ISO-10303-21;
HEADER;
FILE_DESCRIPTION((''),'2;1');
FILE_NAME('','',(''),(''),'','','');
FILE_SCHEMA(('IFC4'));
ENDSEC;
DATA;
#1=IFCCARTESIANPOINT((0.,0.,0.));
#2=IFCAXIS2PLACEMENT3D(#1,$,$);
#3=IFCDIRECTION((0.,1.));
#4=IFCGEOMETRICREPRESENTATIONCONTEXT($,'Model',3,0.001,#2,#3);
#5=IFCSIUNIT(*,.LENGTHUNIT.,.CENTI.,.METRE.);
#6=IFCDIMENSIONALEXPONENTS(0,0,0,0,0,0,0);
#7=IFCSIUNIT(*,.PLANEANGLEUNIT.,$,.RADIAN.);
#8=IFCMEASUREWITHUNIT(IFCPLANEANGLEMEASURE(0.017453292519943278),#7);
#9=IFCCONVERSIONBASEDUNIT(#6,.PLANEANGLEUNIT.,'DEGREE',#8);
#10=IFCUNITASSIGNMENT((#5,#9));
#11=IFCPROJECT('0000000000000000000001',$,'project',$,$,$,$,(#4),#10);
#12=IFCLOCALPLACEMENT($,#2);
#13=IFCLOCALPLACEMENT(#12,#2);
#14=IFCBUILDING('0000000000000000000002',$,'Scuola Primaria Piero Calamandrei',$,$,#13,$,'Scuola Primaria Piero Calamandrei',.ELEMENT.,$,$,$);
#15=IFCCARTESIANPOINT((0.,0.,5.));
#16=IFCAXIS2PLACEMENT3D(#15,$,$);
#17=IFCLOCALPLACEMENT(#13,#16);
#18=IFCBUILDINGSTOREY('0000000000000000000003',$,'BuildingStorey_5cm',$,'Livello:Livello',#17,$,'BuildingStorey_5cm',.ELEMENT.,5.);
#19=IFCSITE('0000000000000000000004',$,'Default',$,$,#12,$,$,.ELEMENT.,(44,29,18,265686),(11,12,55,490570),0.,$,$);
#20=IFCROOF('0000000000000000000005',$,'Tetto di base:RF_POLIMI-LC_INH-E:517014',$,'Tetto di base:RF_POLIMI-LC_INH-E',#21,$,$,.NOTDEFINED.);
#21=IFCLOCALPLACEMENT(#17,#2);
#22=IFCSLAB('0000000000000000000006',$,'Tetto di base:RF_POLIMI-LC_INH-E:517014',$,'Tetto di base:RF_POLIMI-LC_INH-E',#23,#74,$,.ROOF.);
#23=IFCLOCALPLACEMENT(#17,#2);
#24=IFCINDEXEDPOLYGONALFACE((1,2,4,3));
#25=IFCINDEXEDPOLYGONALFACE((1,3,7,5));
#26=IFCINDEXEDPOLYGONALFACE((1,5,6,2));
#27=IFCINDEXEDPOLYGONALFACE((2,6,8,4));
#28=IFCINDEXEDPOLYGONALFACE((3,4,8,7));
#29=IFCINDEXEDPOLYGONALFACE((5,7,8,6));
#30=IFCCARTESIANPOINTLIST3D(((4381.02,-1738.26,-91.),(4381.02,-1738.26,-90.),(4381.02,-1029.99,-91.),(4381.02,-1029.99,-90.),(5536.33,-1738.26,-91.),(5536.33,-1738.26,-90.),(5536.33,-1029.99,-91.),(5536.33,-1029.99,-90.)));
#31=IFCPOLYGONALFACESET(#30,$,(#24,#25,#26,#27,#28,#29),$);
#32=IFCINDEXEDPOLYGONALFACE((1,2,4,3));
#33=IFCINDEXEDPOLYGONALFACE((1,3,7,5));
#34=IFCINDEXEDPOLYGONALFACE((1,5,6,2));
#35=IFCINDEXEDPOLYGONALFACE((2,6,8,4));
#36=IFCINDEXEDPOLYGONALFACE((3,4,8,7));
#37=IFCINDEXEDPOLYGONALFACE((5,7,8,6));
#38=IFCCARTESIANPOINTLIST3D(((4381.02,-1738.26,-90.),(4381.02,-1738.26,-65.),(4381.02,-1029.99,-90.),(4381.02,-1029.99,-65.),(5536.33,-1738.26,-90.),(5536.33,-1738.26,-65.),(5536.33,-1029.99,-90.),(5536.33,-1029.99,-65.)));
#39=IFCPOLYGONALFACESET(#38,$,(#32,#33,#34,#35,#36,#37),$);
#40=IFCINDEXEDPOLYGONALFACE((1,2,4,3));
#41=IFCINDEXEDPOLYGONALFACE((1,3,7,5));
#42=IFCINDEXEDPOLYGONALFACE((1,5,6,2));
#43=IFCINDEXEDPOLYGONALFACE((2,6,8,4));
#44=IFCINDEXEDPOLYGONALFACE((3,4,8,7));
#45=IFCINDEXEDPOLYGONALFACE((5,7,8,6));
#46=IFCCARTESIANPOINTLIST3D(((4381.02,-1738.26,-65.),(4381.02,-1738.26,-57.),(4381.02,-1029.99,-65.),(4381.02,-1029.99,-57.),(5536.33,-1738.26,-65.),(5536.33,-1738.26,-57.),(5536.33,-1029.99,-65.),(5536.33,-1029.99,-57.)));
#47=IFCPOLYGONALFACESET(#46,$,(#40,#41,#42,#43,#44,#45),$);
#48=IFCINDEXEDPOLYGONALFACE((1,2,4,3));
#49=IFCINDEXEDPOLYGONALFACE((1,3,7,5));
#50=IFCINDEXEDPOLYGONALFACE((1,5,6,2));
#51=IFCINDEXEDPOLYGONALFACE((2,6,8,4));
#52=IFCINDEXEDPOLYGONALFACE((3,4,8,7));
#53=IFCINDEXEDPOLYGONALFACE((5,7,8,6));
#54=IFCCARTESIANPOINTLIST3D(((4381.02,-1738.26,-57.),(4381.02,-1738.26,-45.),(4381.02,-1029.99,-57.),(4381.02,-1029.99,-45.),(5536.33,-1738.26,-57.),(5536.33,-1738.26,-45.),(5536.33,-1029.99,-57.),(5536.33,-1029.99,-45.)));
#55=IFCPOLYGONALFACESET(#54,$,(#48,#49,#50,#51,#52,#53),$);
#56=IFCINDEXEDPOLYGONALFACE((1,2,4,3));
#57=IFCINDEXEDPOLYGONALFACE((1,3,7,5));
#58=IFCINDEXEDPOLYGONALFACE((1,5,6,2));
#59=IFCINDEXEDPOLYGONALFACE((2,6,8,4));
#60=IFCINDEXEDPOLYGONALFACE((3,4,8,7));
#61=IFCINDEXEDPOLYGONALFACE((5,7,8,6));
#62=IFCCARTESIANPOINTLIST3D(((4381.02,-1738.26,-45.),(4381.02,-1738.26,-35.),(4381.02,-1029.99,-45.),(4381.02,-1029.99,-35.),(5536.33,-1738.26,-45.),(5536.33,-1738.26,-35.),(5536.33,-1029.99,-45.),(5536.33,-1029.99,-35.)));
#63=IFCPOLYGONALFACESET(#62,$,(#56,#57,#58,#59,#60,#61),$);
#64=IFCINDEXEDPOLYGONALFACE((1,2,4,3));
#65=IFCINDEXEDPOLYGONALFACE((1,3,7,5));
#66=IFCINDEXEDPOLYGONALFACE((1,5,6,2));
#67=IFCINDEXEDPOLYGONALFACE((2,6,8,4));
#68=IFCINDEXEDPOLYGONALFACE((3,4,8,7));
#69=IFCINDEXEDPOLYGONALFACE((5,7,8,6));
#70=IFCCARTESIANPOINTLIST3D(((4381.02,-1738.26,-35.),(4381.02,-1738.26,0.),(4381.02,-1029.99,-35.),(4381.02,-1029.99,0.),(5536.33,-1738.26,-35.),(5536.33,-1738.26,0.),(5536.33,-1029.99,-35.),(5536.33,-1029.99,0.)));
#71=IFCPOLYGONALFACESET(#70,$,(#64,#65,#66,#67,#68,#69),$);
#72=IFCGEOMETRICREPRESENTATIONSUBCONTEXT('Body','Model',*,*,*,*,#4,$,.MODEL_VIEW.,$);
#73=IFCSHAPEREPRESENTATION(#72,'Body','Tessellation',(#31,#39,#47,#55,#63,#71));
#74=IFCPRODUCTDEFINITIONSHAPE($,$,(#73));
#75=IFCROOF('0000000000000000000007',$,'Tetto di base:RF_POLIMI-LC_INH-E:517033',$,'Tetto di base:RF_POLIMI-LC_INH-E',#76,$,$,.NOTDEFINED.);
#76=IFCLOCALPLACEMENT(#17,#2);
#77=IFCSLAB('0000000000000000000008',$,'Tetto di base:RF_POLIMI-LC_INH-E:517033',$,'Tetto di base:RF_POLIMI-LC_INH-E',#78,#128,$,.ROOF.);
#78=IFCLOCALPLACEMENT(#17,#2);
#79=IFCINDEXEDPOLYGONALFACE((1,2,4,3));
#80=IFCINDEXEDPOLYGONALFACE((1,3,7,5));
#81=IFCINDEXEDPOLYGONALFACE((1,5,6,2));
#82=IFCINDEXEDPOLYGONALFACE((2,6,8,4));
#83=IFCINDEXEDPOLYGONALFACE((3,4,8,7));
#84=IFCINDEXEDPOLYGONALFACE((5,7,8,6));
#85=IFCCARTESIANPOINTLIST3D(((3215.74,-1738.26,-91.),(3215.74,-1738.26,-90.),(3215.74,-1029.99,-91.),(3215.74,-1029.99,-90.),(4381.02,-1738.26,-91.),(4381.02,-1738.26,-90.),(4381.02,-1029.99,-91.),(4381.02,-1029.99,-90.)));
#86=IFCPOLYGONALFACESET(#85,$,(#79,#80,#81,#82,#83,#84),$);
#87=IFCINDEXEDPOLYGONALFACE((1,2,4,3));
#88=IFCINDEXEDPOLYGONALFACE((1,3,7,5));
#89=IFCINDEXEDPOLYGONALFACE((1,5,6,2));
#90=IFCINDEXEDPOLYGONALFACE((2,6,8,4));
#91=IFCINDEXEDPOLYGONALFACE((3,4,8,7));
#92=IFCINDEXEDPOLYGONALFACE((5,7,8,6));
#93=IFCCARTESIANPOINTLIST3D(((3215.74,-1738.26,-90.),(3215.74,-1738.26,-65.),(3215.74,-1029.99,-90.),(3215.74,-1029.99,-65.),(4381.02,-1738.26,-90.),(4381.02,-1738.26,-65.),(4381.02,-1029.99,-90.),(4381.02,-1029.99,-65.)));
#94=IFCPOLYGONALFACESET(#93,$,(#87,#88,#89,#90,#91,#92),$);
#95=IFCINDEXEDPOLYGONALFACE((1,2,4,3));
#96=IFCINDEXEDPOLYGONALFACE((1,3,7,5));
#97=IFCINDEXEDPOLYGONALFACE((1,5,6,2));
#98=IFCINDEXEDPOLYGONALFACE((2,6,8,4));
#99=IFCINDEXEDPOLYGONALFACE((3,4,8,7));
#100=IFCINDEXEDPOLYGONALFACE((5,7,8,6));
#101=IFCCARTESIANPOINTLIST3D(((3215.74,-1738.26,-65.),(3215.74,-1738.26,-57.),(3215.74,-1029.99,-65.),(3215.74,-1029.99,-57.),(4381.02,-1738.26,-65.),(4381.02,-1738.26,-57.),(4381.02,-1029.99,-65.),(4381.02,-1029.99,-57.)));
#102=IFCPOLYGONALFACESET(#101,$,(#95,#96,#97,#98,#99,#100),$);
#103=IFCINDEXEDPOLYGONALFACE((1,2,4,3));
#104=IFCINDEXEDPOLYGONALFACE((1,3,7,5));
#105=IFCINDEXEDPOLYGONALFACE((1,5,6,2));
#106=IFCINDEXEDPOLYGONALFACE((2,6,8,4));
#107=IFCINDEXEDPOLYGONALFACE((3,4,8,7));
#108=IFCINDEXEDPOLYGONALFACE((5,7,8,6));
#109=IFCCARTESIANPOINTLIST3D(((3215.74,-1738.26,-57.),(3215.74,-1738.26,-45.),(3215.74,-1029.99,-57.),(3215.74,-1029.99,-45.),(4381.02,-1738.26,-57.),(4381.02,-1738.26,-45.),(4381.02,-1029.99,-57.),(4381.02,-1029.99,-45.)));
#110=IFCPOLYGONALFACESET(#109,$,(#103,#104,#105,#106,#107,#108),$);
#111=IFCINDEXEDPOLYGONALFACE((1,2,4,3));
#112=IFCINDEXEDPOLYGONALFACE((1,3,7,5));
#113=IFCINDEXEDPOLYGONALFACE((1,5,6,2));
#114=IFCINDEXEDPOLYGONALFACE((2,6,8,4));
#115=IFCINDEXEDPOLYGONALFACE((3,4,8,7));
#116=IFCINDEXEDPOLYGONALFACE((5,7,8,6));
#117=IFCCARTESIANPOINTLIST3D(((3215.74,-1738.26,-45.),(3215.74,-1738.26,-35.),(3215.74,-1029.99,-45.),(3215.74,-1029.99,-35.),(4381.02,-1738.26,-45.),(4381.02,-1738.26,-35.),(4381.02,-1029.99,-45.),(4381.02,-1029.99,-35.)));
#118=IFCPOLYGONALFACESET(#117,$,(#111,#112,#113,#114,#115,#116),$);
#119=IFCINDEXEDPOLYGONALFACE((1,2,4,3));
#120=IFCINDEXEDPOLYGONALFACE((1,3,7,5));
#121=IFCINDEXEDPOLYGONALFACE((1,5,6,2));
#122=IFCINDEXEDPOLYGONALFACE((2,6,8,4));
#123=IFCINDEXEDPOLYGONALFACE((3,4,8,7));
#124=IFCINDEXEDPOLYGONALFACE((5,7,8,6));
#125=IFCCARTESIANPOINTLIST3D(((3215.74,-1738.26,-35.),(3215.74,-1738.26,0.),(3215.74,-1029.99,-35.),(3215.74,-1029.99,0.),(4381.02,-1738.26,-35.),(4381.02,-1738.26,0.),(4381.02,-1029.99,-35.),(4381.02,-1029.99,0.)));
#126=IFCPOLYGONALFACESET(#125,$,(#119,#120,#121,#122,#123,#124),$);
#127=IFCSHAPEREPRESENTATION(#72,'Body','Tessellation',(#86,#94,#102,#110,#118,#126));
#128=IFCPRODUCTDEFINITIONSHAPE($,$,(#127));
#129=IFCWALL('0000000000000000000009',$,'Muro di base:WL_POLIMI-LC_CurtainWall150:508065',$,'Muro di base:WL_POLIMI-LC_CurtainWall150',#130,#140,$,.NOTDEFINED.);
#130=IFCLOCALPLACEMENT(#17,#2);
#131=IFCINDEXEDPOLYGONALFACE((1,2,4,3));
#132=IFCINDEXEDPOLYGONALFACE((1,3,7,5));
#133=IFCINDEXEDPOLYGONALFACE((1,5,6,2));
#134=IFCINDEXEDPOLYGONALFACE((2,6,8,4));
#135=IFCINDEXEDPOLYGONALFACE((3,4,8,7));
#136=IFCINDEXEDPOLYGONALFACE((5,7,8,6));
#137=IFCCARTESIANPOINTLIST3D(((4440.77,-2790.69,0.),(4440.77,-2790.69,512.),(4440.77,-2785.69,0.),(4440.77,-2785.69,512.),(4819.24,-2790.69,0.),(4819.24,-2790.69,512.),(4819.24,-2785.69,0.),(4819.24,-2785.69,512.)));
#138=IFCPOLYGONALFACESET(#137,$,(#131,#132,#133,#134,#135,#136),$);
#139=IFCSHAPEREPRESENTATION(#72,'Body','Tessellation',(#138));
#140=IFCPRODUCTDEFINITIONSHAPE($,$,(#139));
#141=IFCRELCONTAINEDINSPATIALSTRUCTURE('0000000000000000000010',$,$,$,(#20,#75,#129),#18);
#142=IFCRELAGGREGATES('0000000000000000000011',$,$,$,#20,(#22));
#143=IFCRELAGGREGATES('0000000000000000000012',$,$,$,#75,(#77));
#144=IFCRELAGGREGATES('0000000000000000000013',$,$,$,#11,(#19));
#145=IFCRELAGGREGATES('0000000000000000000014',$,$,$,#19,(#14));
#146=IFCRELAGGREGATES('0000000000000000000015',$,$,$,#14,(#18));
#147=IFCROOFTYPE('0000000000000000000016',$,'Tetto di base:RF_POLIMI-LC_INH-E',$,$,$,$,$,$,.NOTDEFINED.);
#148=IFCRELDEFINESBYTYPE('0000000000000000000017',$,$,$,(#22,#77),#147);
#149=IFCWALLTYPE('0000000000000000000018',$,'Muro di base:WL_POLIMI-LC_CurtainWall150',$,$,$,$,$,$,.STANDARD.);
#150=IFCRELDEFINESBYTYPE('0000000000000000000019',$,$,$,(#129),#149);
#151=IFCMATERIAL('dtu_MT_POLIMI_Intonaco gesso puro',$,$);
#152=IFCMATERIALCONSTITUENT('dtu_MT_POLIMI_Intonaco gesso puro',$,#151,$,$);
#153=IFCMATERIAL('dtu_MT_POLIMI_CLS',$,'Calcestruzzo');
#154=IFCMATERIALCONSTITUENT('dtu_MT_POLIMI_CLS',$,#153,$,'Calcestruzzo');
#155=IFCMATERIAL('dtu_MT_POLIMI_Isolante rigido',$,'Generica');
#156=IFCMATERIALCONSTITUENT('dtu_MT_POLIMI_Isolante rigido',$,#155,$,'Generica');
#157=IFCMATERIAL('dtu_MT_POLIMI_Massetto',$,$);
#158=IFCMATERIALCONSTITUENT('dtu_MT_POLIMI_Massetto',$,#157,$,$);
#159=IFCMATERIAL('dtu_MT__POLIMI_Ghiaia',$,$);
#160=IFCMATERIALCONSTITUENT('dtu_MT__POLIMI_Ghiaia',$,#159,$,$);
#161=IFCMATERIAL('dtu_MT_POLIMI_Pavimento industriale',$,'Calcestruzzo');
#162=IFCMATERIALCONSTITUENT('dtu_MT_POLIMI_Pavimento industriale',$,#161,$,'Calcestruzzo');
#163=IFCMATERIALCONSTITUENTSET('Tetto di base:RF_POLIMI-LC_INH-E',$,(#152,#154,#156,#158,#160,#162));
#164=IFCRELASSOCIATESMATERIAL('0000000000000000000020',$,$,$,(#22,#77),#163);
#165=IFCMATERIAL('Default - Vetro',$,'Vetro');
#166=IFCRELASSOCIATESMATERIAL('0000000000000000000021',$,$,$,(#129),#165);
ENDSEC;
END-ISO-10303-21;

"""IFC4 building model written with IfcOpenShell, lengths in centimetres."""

from ifc_helpers import new_model, entity, si_unit, converted_unit, direction, frame, origin, place, context, subcontext, project, spatial, indexed_curve, outline, extrude, material, constituent, constituent_set, type_object, element, aggregate, save


model = new_model("IFC4")

# Units and contexts
model_context = context("Model", 3, precision=0.001, world=origin(), true_north=direction((0.0, 1.0)))
body_context = subcontext(model_context, "Body", "Model", "MODEL_VIEW")
ifc_project = project(units=[si_unit("LENGTHUNIT", "METRE", prefix="CENTI"), converted_unit("PLANEANGLEUNIT", "DEGREE", entity("IfcPlaneAngleMeasure", 0.017453292519943278), si_unit("PLANEANGLEUNIT", "RADIAN"), dimensions=[0, 0, 0, 0, 0, 0, 0])], contexts=[model_context])

# Site, building, storey
site_placement = place(None, origin())
site = spatial("IfcSite", under=ifc_project, at=site_placement, Name="Default", CompositionType="ELEMENT", RefLatitude=(44, 29, 18, 265686), RefLongitude=(11, 12, 55, 490570), RefElevation=0.0)
building_placement = place(site_placement, origin())
building = spatial("IfcBuilding", under=site, at=building_placement, Name="Scuola Primaria Piero Calamandrei", LongName="Scuola Primaria Piero Calamandrei", CompositionType="ELEMENT")
storey_placement = place(building_placement, frame((0.0, 0.0, 5.0)))
storey = spatial("IfcBuildingStorey", under=building, at=storey_placement, Name="BuildingStorey_5cm", ObjectType="Livello:Livello", LongName="BuildingStorey_5cm", CompositionType="ELEMENT", Elevation=5.0)

# Roofs, slabs
roof_1_placement = place(storey_placement, frame((4381.02, -1738.26, -91.0)))
roof_1 = element("IfcRoof", 1, at=roof_1_placement, inside=storey, Name="Tetto di base:RF_POLIMI-LC_INH-E:517014", ObjectType="Tetto di base:RF_POLIMI-LC_INH-E", PredefinedType="NOTDEFINED")
ifc_material_1 = material(Name="dtu_MT_POLIMI_Intonaco gesso puro")
ifc_constituent_1 = constituent(ifc_material_1, Name="dtu_MT_POLIMI_Intonaco gesso puro")
ifc_material_2 = material(Name="dtu_MT_POLIMI_CLS", Category="Calcestruzzo")
ifc_constituent_2 = constituent(ifc_material_2, Name="dtu_MT_POLIMI_CLS", Category="Calcestruzzo")
ifc_material_3 = material(Name="dtu_MT_POLIMI_Isolante rigido", Category="Generica")
ifc_constituent_3 = constituent(ifc_material_3, Name="dtu_MT_POLIMI_Isolante rigido", Category="Generica")
ifc_material_4 = material(Name="dtu_MT_POLIMI_Massetto")
ifc_constituent_4 = constituent(ifc_material_4, Name="dtu_MT_POLIMI_Massetto")
ifc_material_5 = material(Name="dtu_MT__POLIMI_Ghiaia")
ifc_constituent_5 = constituent(ifc_material_5, Name="dtu_MT__POLIMI_Ghiaia")
ifc_material_6 = material(Name="dtu_MT_POLIMI_Pavimento industriale", Category="Calcestruzzo")
ifc_constituent_6 = constituent(ifc_material_6, Name="dtu_MT_POLIMI_Pavimento industriale", Category="Calcestruzzo")
ifc_constituent_set_1 = constituent_set(constituents=[ifc_constituent_1, ifc_constituent_2, ifc_constituent_3, ifc_constituent_4, ifc_constituent_5, ifc_constituent_6], Name="Tetto di base:RF_POLIMI-LC_INH-E")
roof_type = type_object("IfcRoofType", Name="Tetto di base:RF_POLIMI-LC_INH-E", PredefinedType="NOTDEFINED")
slab_1_placement = place(roof_1_placement, origin())
slab_1 = element("IfcSlab", 2, at=slab_1_placement, type_object=roof_type, material=ifc_constituent_set_1, Name="Tetto di base:RF_POLIMI-LC_INH-E:517014", ObjectType="Tetto di base:RF_POLIMI-LC_INH-E", PredefinedType="ROOF", context=body_context, shape_type="SweptSolid", body=[
    extrude(outline(indexed_curve([(577.66, 354.13), (-577.66, 354.13), (-577.66, -354.13), (577.66, -354.13), (577.66, 354.13)], self_intersect=False)), frame((577.66, 354.13, 0.0)), (0.0, 0.0, 1.0), 1.0),
    extrude(outline(indexed_curve([(577.66, 354.13), (-577.66, 354.13), (-577.66, -354.13), (577.66, -354.13), (577.66, 354.13)], self_intersect=False)), frame((577.66, 354.13, 1.0)), (0.0, 0.0, 1.0), 25.0),
    extrude(outline(indexed_curve([(577.66, 354.13), (-577.66, 354.13), (-577.66, -354.13), (577.66, -354.13), (577.66, 354.13)], self_intersect=False)), frame((577.66, 354.13, 26.0)), (0.0, 0.0, 1.0), 8.0),
    extrude(outline(indexed_curve([(577.66, 354.13), (-577.66, 354.13), (-577.66, -354.13), (577.66, -354.13), (577.66, 354.13)], self_intersect=False)), frame((577.66, 354.13, 34.0)), (0.0, 0.0, 1.0), 12.0),
    extrude(outline(indexed_curve([(577.66, 354.13), (-577.66, 354.13), (-577.66, -354.13), (577.66, -354.13), (577.66, 354.13)], self_intersect=False)), frame((577.66, 354.13, 46.0)), (0.0, 0.0, 1.0), 10.0),
    extrude(outline(indexed_curve([(577.66, 354.13), (-577.66, 354.13), (-577.66, -354.13), (577.66, -354.13), (577.66, 354.13)], self_intersect=False)), frame((577.66, 354.13, 56.0)), (0.0, 0.0, 1.0), 35.0),
])
aggregate(roof_1, [slab_1])
roof_2_placement = place(storey_placement, frame((3215.74, -1738.26, -91.0)))
roof_2 = element("IfcRoof", 3, at=roof_2_placement, inside=storey, Name="Tetto di base:RF_POLIMI-LC_INH-E:517033", ObjectType="Tetto di base:RF_POLIMI-LC_INH-E", PredefinedType="NOTDEFINED")
slab_2_placement = place(roof_2_placement, origin())
slab_2 = element("IfcSlab", 4, at=slab_2_placement, type_object=roof_type, material=ifc_constituent_set_1, Name="Tetto di base:RF_POLIMI-LC_INH-E:517033", ObjectType="Tetto di base:RF_POLIMI-LC_INH-E", PredefinedType="ROOF", context=body_context, shape_type="SweptSolid", body=[
    extrude(outline(indexed_curve([(582.64, 354.13), (-582.64, 354.13), (-582.64, -354.13), (582.64, -354.13), (582.64, 354.13)], self_intersect=False)), frame((582.64, 354.13, 0.0)), (0.0, 0.0, 1.0), 1.0),
    extrude(outline(indexed_curve([(582.64, 354.13), (-582.64, 354.13), (-582.64, -354.13), (582.64, -354.13), (582.64, 354.13)], self_intersect=False)), frame((582.64, 354.13, 1.0)), (0.0, 0.0, 1.0), 25.0),
    extrude(outline(indexed_curve([(582.64, 354.13), (-582.64, 354.13), (-582.64, -354.13), (582.64, -354.13), (582.64, 354.13)], self_intersect=False)), frame((582.64, 354.13, 26.0)), (0.0, 0.0, 1.0), 8.0),
    extrude(outline(indexed_curve([(582.64, 354.13), (-582.64, 354.13), (-582.64, -354.13), (582.64, -354.13), (582.64, 354.13)], self_intersect=False)), frame((582.64, 354.13, 34.0)), (0.0, 0.0, 1.0), 12.0),
    extrude(outline(indexed_curve([(582.64, 354.13), (-582.64, 354.13), (-582.64, -354.13), (582.64, -354.13), (582.64, 354.13)], self_intersect=False)), frame((582.64, 354.13, 46.0)), (0.0, 0.0, 1.0), 10.0),
    extrude(outline(indexed_curve([(582.64, 354.13), (-582.64, 354.13), (-582.64, -354.13), (582.64, -354.13), (582.64, 354.13)], self_intersect=False)), frame((582.64, 354.13, 56.0)), (0.0, 0.0, 1.0), 35.0),
])
aggregate(roof_2, [slab_2])

# Wall
ifc_material_7 = material(Name="Default - Vetro", Category="Vetro")
wall_type_1 = type_object("IfcWallType", Name="Muro di base:WL_POLIMI-LC_CurtainWall150", PredefinedType="STANDARD")
wall_1_placement = place(storey_placement, frame((4440.77, -2788.19, 0.0)))
element("IfcWall", 5, at=wall_1_placement, inside=storey, type_object=wall_type_1, material=ifc_material_7, Name="Muro di base:WL_POLIMI-LC_CurtainWall150:508065", ObjectType="Muro di base:WL_POLIMI-LC_CurtainWall150", PredefinedType="NOTDEFINED", context=body_context, shape_type="SweptSolid", body=[
    extrude(outline(indexed_curve([(-2.5, -189.23), (2.5, -189.23), (2.5, 189.23), (-2.5, 189.23), (-2.5, -189.23)], self_intersect=False)), frame((189.23, 0.0, 0.0), z_axis=(0.0, 0.0, 1.0), x_axis=(0.0, 1.0, 0.0)), (0.0, 0.0, 1.0), 512.0),
])

save(model, "model.ifc")
